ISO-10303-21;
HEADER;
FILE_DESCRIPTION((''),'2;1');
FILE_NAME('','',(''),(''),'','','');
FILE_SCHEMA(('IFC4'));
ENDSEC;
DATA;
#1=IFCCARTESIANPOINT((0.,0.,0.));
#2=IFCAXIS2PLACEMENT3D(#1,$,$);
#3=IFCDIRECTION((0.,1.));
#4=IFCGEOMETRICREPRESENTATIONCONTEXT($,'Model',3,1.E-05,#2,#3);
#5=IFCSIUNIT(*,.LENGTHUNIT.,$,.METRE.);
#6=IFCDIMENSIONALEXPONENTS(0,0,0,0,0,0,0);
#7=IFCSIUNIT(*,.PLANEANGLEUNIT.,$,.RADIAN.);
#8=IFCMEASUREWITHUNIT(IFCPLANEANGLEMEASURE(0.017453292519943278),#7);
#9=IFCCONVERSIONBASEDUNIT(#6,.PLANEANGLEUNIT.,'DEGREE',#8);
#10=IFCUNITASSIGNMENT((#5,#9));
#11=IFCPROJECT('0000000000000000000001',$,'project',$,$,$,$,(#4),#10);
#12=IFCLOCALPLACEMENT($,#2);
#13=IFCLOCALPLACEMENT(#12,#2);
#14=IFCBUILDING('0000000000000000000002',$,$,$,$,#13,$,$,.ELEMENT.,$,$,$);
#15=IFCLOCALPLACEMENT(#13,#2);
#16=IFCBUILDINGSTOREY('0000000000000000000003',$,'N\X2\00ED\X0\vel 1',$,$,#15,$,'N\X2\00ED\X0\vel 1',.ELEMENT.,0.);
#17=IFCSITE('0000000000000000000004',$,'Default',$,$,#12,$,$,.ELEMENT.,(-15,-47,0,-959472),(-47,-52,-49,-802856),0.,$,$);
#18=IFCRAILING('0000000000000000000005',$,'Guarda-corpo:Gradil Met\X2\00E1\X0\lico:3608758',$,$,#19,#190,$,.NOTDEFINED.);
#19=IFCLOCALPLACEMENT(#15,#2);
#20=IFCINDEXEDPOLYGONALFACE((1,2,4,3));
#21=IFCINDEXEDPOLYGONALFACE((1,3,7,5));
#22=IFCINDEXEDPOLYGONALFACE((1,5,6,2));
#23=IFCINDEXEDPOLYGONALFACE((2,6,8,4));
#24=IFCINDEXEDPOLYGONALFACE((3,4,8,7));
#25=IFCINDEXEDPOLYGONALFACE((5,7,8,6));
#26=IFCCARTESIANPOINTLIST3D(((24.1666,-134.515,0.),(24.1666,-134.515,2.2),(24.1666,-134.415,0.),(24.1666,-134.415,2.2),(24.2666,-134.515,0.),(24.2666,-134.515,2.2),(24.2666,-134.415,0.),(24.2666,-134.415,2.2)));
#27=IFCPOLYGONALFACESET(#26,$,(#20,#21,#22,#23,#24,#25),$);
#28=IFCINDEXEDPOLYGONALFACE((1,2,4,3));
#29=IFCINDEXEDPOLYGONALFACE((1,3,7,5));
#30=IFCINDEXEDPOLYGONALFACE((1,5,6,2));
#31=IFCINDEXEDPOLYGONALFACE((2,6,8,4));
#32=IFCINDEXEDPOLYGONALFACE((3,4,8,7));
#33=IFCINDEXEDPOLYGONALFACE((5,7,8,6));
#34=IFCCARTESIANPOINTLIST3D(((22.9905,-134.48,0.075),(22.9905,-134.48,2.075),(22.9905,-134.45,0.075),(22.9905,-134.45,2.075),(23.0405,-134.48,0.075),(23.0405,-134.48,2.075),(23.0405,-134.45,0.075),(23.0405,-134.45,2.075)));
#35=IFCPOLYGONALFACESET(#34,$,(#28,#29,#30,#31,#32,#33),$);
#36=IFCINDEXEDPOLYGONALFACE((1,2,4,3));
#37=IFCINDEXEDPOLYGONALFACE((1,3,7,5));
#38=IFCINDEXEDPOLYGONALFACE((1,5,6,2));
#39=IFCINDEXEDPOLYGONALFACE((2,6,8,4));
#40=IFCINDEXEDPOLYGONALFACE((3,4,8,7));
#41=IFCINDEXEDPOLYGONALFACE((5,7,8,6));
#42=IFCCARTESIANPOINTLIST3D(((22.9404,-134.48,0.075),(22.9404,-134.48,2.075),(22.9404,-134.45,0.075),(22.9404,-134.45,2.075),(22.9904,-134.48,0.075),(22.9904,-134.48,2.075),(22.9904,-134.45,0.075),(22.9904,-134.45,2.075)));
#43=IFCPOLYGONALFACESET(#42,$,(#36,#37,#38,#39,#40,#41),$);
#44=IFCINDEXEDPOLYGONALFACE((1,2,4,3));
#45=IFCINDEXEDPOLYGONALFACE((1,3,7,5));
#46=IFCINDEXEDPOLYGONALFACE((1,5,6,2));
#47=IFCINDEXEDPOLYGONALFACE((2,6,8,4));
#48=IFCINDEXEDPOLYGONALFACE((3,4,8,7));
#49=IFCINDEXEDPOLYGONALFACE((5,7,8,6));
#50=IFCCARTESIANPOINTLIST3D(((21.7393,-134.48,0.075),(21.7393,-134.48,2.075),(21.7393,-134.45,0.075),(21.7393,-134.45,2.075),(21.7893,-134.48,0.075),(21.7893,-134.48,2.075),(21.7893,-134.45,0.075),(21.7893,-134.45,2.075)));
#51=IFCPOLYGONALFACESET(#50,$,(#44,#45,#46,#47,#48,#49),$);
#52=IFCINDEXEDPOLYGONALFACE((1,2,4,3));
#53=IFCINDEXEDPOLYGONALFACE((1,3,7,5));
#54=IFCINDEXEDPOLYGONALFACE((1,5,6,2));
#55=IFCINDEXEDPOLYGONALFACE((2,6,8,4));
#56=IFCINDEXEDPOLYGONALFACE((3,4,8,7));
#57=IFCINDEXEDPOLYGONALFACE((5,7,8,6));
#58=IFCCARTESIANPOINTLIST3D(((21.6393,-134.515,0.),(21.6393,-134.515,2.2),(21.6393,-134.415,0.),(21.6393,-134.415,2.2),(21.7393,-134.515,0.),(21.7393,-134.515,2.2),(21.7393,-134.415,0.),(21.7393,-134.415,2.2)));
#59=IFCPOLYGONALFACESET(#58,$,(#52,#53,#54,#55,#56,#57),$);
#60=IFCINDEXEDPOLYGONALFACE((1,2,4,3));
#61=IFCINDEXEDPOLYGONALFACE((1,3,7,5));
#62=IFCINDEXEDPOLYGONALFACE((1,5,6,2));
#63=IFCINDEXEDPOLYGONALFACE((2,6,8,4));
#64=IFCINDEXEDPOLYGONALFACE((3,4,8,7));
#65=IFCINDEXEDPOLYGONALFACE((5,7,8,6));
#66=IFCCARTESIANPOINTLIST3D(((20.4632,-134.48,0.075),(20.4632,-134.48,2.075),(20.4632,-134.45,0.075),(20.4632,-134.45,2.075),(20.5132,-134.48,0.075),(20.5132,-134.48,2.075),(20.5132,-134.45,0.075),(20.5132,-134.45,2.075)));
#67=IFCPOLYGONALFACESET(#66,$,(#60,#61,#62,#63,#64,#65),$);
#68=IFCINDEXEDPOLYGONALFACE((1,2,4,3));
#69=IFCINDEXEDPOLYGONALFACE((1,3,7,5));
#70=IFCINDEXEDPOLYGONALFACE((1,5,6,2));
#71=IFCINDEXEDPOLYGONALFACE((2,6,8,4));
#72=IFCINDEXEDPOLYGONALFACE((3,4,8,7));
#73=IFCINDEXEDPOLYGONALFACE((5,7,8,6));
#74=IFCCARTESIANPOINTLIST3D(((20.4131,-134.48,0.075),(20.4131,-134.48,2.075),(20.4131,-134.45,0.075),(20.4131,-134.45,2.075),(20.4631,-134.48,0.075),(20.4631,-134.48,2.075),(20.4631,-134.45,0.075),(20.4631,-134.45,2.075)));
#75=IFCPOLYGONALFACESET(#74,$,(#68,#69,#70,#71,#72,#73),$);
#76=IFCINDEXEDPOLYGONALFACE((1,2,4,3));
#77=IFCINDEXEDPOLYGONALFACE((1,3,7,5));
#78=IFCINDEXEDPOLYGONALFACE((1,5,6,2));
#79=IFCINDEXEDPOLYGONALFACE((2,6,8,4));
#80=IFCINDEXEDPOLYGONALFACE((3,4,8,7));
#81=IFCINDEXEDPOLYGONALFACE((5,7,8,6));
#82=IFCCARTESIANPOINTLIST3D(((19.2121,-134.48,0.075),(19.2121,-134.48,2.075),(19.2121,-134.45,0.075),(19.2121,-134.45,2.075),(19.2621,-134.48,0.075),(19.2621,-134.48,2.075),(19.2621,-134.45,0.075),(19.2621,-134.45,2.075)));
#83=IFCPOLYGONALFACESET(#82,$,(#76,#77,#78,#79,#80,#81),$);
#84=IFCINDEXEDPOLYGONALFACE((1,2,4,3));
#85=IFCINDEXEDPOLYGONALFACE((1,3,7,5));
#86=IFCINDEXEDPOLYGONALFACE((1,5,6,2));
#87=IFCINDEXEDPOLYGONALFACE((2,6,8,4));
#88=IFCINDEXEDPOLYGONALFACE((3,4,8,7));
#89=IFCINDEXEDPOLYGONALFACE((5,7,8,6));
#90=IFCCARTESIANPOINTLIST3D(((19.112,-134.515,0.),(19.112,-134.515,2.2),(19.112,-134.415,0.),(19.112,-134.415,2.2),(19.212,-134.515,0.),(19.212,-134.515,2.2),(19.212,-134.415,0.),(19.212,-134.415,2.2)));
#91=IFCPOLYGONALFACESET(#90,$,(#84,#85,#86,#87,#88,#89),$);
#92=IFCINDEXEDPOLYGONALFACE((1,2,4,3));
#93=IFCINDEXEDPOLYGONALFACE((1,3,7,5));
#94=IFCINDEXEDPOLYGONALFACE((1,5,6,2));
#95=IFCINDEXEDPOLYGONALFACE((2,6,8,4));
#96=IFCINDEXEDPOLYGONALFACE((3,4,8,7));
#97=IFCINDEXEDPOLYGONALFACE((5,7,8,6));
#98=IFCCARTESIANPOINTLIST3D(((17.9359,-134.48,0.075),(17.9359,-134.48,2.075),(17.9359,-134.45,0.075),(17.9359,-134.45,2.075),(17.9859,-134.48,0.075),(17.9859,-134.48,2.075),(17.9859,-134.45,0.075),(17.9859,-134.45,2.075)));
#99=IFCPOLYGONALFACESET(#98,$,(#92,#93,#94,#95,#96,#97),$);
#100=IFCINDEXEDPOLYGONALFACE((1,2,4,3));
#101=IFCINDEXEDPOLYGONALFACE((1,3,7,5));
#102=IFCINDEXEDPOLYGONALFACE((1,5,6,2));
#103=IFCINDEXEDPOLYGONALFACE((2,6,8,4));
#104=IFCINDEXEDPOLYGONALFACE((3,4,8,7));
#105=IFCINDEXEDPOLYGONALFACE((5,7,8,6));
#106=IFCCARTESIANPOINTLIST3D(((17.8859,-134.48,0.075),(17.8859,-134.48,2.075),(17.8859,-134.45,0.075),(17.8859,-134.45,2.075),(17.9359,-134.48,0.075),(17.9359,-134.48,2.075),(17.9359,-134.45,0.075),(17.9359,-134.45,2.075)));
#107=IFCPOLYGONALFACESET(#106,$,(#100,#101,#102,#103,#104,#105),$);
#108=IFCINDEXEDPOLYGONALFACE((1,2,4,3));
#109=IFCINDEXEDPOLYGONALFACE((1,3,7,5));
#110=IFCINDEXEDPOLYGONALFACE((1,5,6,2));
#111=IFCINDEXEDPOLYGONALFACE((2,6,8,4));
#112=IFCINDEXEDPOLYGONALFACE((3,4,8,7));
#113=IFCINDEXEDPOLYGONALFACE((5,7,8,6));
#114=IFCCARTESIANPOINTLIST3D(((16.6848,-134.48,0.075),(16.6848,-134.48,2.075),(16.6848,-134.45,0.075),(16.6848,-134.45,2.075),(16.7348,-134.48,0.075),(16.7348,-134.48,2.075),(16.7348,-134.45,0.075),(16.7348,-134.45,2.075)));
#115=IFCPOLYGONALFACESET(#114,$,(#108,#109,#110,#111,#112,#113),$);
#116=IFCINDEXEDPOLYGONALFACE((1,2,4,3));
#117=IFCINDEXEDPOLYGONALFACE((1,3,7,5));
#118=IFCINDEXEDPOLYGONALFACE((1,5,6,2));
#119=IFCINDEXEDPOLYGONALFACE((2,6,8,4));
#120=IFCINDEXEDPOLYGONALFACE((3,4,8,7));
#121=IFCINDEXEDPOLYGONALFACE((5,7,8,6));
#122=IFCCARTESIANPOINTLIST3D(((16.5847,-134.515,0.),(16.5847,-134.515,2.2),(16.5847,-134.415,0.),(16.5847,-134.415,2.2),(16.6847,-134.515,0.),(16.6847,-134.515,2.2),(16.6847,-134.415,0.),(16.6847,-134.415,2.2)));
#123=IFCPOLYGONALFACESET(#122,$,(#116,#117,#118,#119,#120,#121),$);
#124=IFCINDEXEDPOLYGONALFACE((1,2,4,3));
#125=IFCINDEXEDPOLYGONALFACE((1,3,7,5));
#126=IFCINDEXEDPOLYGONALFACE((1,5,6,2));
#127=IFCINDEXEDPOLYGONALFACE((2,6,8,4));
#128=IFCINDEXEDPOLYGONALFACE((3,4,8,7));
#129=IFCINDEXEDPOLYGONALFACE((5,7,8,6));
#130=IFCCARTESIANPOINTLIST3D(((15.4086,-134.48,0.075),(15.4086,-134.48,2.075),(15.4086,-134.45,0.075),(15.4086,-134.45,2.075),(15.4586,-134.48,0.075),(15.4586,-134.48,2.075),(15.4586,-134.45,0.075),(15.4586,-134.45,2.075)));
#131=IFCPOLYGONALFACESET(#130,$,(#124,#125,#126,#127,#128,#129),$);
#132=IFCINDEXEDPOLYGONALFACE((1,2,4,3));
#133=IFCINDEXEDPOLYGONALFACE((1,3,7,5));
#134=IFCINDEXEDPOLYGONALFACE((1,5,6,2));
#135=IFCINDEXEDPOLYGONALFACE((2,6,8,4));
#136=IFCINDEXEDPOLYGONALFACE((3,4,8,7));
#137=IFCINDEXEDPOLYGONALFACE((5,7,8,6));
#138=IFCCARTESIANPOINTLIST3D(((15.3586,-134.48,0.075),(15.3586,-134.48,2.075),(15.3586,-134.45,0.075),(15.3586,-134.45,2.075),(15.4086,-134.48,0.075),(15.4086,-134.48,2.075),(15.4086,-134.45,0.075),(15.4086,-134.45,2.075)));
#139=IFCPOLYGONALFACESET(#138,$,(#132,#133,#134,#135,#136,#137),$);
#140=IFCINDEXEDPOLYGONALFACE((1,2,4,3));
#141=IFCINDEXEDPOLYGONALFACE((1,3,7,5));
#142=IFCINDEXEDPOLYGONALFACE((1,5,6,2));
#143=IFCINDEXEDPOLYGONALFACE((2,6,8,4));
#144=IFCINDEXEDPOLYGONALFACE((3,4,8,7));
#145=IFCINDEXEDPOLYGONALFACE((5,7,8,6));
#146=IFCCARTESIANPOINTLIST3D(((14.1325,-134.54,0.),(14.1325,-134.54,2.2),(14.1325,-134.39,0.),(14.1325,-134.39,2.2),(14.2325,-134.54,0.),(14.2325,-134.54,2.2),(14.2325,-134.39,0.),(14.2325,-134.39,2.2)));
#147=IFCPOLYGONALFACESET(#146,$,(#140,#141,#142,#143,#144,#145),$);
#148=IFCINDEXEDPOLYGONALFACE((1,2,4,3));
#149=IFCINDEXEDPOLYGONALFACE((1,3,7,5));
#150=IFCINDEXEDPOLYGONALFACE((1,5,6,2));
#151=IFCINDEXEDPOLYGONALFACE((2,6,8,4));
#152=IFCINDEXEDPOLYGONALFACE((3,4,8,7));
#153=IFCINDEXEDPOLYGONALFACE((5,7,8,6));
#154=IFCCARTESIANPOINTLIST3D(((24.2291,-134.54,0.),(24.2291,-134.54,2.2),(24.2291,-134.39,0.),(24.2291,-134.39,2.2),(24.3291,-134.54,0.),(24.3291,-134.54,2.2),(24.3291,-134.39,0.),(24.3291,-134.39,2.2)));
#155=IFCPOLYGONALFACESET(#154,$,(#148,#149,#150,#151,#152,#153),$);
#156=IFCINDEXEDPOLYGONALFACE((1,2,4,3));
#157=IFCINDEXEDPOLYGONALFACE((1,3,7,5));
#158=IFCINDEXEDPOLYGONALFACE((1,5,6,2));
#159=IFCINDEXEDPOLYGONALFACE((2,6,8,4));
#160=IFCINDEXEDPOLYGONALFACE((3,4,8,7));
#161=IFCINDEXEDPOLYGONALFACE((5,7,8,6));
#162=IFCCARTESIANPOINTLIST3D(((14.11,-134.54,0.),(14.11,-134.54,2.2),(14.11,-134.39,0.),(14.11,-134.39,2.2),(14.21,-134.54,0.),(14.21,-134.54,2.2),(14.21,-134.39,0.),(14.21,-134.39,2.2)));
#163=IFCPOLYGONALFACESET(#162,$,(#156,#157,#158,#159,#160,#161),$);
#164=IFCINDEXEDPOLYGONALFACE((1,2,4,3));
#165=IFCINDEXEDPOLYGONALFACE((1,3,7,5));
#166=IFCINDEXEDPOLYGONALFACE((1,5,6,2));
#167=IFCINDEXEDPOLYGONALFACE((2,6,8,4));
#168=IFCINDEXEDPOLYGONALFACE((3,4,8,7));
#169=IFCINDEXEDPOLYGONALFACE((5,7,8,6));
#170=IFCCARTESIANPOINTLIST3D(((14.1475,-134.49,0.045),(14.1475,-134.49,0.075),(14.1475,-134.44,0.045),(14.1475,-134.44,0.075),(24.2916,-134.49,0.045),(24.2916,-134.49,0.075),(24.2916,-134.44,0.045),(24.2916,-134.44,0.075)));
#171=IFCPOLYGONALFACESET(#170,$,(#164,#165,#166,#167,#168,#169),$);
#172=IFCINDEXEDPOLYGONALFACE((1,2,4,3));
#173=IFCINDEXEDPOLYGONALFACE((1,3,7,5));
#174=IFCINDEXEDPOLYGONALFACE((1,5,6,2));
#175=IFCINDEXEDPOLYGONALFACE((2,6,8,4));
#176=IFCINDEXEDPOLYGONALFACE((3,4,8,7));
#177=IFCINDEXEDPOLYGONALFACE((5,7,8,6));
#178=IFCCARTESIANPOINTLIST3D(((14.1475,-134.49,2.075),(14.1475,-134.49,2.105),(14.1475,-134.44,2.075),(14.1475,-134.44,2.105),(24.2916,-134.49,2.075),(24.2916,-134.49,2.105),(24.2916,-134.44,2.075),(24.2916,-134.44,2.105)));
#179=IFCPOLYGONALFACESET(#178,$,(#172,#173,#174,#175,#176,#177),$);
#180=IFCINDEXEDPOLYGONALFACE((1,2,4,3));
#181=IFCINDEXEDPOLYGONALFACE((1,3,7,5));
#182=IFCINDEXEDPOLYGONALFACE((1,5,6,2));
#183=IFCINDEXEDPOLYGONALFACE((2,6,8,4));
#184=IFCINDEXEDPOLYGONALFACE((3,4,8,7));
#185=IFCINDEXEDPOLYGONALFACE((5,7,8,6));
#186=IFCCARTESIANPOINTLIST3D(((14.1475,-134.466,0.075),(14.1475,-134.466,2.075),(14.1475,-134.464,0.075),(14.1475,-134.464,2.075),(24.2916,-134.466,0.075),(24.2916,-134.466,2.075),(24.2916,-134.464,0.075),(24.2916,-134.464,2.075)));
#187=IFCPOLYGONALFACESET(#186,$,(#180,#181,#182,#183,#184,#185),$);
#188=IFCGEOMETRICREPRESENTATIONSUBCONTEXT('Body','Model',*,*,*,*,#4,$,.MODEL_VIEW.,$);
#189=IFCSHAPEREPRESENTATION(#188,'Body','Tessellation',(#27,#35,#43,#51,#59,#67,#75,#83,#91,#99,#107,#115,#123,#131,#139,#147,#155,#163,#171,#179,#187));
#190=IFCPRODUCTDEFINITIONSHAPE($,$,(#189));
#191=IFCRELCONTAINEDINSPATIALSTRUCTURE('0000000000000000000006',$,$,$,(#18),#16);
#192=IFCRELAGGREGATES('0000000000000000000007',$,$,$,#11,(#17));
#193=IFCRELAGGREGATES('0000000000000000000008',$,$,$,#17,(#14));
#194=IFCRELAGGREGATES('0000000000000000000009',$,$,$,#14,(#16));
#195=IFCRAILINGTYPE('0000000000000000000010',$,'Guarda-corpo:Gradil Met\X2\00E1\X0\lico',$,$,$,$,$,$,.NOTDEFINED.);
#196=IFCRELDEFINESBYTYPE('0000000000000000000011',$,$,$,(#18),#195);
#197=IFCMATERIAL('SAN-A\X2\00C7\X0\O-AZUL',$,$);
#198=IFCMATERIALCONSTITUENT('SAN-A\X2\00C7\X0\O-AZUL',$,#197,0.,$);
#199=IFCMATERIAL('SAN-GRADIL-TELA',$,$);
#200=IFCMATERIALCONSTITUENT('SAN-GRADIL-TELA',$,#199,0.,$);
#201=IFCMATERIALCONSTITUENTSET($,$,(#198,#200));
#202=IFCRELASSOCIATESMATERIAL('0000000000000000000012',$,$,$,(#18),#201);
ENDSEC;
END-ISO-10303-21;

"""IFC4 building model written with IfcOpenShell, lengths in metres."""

from ifc_helpers import new_model, entity, si_unit, converted_unit, direction, frame, origin, place, context, subcontext, project, spatial, indexed_curve, outline, extrude, material, constituent, constituent_set, type_object, element, save


model = new_model("IFC4")

# Units and contexts
model_context = context("Model", 3, precision=1e-05, world=origin(), true_north=direction((0.0, 1.0)))
body_context = subcontext(model_context, "Body", "Model", "MODEL_VIEW")
ifc_project = project(units=[si_unit("LENGTHUNIT", "METRE"), converted_unit("PLANEANGLEUNIT", "DEGREE", entity("IfcPlaneAngleMeasure", 0.017453292519943278), si_unit("PLANEANGLEUNIT", "RADIAN"), dimensions=[0, 0, 0, 0, 0, 0, 0])], contexts=[model_context])

# Site, building, storey
site_placement = place(None, origin())
site = spatial("IfcSite", under=ifc_project, at=site_placement, Name="Default", CompositionType="ELEMENT", RefLatitude=(-15, -47, 0, -959472), RefLongitude=(-47, -52, -49, -802856), RefElevation=0.0)
building_placement = place(site_placement, origin())
building = spatial("IfcBuilding", under=site, at=building_placement, CompositionType="ELEMENT")
storey_placement = place(building_placement, origin())
storey = spatial("IfcBuildingStorey", under=building, at=storey_placement, Name="Nível 1", LongName="Nível 1", CompositionType="ELEMENT", Elevation=0.0)

# Shared definitions
ifc_material_1 = material(Name="SAN-AÇO-AZUL")
ifc_material_2 = material(Name="SAN-GRADIL-TELA")

# Railing
railing_type = type_object("IfcRailingType", Name="Guarda-corpo:Gradil Metálico", PredefinedType="NOTDEFINED")
ifc_constituent_1 = constituent(ifc_material_1, Name="SAN-AÇO-AZUL", fraction=0.0)
ifc_constituent_2 = constituent(ifc_material_2, Name="SAN-GRADIL-TELA", fraction=0.0)
ifc_constituent_set_1 = constituent_set(constituents=[ifc_constituent_1, ifc_constituent_2])
railing_1_placement = place(storey_placement, frame((14.11, -134.54, 0.0)))
element("IfcRailing", 1, at=railing_1_placement, inside=storey, type_object=railing_type, material=ifc_constituent_set_1, Name="Guarda-corpo:Gradil Metálico:3608758", PredefinedType="NOTDEFINED", context=body_context, shape_type="SweptSolid", body=[
    extrude(outline(indexed_curve([(-0.05, -0.05), (0.05, -0.05), (0.05, 0.05), (-0.05, 0.05), (-0.05, -0.05)], self_intersect=False)), frame((10.1066, 0.075, 0.0), z_axis=(0.0, 0.0, 1.0), x_axis=(0.0, -1.0, 0.0)), (0.0, 0.0, 1.0), 2.2),
    extrude(outline(indexed_curve([(-0.015, -0.025), (0.015, -0.025), (0.015, 0.025), (-0.015, 0.025), (-0.015, -0.025)], self_intersect=False)), frame((8.9055, 0.075, 0.075), z_axis=(0.0, 0.0, 1.0), x_axis=(0.0, -1.0, 0.0)), (0.0, 0.0, 1.0), 2.0),
    extrude(outline(indexed_curve([(-0.015, -0.025), (0.015, -0.025), (0.015, 0.025), (-0.015, 0.025), (-0.015, -0.025)], self_intersect=False)), frame((8.8555, 0.075, 0.075), z_axis=(0.0, 0.0, 1.0), x_axis=(0.0, -1.0, 0.0)), (0.0, 0.0, 1.0), 2.0),
    extrude(outline(indexed_curve([(-0.015, -0.025), (0.015, -0.025), (0.015, 0.025), (-0.015, 0.025), (-0.015, -0.025)], self_intersect=False)), frame((7.6544, 0.075, 0.075), z_axis=(0.0, 0.0, 1.0), x_axis=(0.0, -1.0, 0.0)), (0.0, 0.0, 1.0), 2.0),
    extrude(outline(indexed_curve([(-0.05, -0.05), (0.05, -0.05), (0.05, 0.05), (-0.05, 0.05), (-0.05, -0.05)], self_intersect=False)), frame((7.5793, 0.075, 0.0), z_axis=(0.0, 0.0, 1.0), x_axis=(0.0, -1.0, 0.0)), (0.0, 0.0, 1.0), 2.2),
    extrude(outline(indexed_curve([(-0.015, -0.025), (0.015, -0.025), (0.015, 0.025), (-0.015, 0.025), (-0.015, -0.025)], self_intersect=False)), frame((6.3782, 0.075, 0.075), z_axis=(0.0, 0.0, 1.0), x_axis=(0.0, -1.0, 0.0)), (0.0, 0.0, 1.0), 2.0),
    extrude(outline(indexed_curve([(-0.015, -0.025), (0.015, -0.025), (0.015, 0.025), (-0.015, 0.025), (-0.015, -0.025)], self_intersect=False)), frame((6.3282, 0.075, 0.075), z_axis=(0.0, 0.0, 1.0), x_axis=(0.0, -1.0, 0.0)), (0.0, 0.0, 1.0), 2.0),
    extrude(outline(indexed_curve([(-0.015, -0.025), (0.015, -0.025), (0.015, 0.025), (-0.015, 0.025), (-0.015, -0.025)], self_intersect=False)), frame((5.1271, 0.075, 0.075), z_axis=(0.0, 0.0, 1.0), x_axis=(0.0, -1.0, 0.0)), (0.0, 0.0, 1.0), 2.0),
    extrude(outline(indexed_curve([(-0.05, -0.05), (0.05, -0.05), (0.05, 0.05), (-0.05, 0.05), (-0.05, -0.05)], self_intersect=False)), frame((5.052, 0.075, 0.0), z_axis=(0.0, 0.0, 1.0), x_axis=(0.0, -1.0, 0.0)), (0.0, 0.0, 1.0), 2.2),
    extrude(outline(indexed_curve([(-0.015, -0.025), (0.015, -0.025), (0.015, 0.025), (-0.015, 0.025), (-0.015, -0.025)], self_intersect=False)), frame((3.8509, 0.075, 0.075), z_axis=(0.0, 0.0, 1.0), x_axis=(0.0, -1.0, 0.0)), (0.0, 0.0, 1.0), 2.0),
    extrude(outline(indexed_curve([(-0.015, -0.025), (0.015, -0.025), (0.015, 0.025), (-0.015, 0.025), (-0.015, -0.025)], self_intersect=False)), frame((3.8009, 0.075, 0.075), z_axis=(0.0, 0.0, 1.0), x_axis=(0.0, -1.0, 0.0)), (0.0, 0.0, 1.0), 2.0),
    extrude(outline(indexed_curve([(-0.015, -0.025), (0.015, -0.025), (0.015, 0.025), (-0.015, 0.025), (-0.015, -0.025)], self_intersect=False)), frame((2.5998, 0.075, 0.075), z_axis=(0.0, 0.0, 1.0), x_axis=(0.0, -1.0, 0.0)), (0.0, 0.0, 1.0), 2.0),
    extrude(outline(indexed_curve([(-0.05, -0.05), (0.05, -0.05), (0.05, 0.05), (-0.05, 0.05), (-0.05, -0.05)], self_intersect=False)), frame((2.5247, 0.075, 0.0), z_axis=(0.0, 0.0, 1.0), x_axis=(0.0, -1.0, 0.0)), (0.0, 0.0, 1.0), 2.2),
    extrude(outline(indexed_curve([(-0.015, -0.025), (0.015, -0.025), (0.015, 0.025), (-0.015, 0.025), (-0.015, -0.025)], self_intersect=False)), frame((1.3236, 0.075, 0.075), z_axis=(0.0, 0.0, 1.0), x_axis=(0.0, -1.0, 0.0)), (0.0, 0.0, 1.0), 2.0),
    extrude(outline(indexed_curve([(-0.015, -0.025), (0.015, -0.025), (0.015, 0.025), (-0.015, 0.025), (-0.015, -0.025)], self_intersect=False)), frame((1.2736, 0.075, 0.075), z_axis=(0.0, 0.0, 1.0), x_axis=(0.0, -1.0, 0.0)), (0.0, 0.0, 1.0), 2.0),
    extrude(outline(indexed_curve([(-0.075, -0.05), (0.075, -0.05), (0.075, 0.05), (-0.075, 0.05), (-0.075, -0.05)], self_intersect=False)), frame((0.0725, 0.075, 0.0), z_axis=(0.0, 0.0, 1.0), x_axis=(0.0, -1.0, 0.0)), (0.0, 0.0, 1.0), 2.2),
    extrude(outline(indexed_curve([(-0.075, -0.05), (0.075, -0.05), (0.075, 0.05), (-0.075, 0.05), (-0.075, -0.05)], self_intersect=False)), frame((10.1692, 0.075, 0.0), z_axis=(0.0, 0.0, 1.0), x_axis=(0.0, -1.0, 0.0)), (0.0, 0.0, 1.0), 2.2),
    extrude(outline(indexed_curve([(-0.075, -0.05), (0.075, -0.05), (0.075, 0.05), (-0.075, 0.05), (-0.075, -0.05)], self_intersect=False)), frame((0.05, 0.075, 0.0), z_axis=(0.0, 0.0, 1.0), x_axis=(0.0, -1.0, 0.0)), (0.0, 0.0, 1.0), 2.2),
    extrude(outline(indexed_curve([(-5.0721, -0.025), (5.0721, -0.025), (5.0721, 0.025), (-5.0721, 0.025), (-5.0721, -0.025)], self_intersect=False)), frame((5.1096, 0.075, 0.045)), (0.0, 0.0, 1.0), 0.03),
    extrude(outline(indexed_curve([(-5.0721, -0.025), (5.0721, -0.025), (5.0721, 0.025), (-5.0721, 0.025), (-5.0721, -0.025)], self_intersect=False)), frame((5.1096, 0.075, 2.075)), (0.0, 0.0, 1.0), 0.03),
    extrude(outline(indexed_curve([(-5.0721, -0.001), (5.0721, -0.001), (5.0721, 0.001), (-5.0721, 0.001), (-5.0721, -0.001)], self_intersect=False)), frame((5.1096, 0.075, 0.075)), (0.0, 0.0, 1.0), 2.0),
])

save(model, "model.ifc")
